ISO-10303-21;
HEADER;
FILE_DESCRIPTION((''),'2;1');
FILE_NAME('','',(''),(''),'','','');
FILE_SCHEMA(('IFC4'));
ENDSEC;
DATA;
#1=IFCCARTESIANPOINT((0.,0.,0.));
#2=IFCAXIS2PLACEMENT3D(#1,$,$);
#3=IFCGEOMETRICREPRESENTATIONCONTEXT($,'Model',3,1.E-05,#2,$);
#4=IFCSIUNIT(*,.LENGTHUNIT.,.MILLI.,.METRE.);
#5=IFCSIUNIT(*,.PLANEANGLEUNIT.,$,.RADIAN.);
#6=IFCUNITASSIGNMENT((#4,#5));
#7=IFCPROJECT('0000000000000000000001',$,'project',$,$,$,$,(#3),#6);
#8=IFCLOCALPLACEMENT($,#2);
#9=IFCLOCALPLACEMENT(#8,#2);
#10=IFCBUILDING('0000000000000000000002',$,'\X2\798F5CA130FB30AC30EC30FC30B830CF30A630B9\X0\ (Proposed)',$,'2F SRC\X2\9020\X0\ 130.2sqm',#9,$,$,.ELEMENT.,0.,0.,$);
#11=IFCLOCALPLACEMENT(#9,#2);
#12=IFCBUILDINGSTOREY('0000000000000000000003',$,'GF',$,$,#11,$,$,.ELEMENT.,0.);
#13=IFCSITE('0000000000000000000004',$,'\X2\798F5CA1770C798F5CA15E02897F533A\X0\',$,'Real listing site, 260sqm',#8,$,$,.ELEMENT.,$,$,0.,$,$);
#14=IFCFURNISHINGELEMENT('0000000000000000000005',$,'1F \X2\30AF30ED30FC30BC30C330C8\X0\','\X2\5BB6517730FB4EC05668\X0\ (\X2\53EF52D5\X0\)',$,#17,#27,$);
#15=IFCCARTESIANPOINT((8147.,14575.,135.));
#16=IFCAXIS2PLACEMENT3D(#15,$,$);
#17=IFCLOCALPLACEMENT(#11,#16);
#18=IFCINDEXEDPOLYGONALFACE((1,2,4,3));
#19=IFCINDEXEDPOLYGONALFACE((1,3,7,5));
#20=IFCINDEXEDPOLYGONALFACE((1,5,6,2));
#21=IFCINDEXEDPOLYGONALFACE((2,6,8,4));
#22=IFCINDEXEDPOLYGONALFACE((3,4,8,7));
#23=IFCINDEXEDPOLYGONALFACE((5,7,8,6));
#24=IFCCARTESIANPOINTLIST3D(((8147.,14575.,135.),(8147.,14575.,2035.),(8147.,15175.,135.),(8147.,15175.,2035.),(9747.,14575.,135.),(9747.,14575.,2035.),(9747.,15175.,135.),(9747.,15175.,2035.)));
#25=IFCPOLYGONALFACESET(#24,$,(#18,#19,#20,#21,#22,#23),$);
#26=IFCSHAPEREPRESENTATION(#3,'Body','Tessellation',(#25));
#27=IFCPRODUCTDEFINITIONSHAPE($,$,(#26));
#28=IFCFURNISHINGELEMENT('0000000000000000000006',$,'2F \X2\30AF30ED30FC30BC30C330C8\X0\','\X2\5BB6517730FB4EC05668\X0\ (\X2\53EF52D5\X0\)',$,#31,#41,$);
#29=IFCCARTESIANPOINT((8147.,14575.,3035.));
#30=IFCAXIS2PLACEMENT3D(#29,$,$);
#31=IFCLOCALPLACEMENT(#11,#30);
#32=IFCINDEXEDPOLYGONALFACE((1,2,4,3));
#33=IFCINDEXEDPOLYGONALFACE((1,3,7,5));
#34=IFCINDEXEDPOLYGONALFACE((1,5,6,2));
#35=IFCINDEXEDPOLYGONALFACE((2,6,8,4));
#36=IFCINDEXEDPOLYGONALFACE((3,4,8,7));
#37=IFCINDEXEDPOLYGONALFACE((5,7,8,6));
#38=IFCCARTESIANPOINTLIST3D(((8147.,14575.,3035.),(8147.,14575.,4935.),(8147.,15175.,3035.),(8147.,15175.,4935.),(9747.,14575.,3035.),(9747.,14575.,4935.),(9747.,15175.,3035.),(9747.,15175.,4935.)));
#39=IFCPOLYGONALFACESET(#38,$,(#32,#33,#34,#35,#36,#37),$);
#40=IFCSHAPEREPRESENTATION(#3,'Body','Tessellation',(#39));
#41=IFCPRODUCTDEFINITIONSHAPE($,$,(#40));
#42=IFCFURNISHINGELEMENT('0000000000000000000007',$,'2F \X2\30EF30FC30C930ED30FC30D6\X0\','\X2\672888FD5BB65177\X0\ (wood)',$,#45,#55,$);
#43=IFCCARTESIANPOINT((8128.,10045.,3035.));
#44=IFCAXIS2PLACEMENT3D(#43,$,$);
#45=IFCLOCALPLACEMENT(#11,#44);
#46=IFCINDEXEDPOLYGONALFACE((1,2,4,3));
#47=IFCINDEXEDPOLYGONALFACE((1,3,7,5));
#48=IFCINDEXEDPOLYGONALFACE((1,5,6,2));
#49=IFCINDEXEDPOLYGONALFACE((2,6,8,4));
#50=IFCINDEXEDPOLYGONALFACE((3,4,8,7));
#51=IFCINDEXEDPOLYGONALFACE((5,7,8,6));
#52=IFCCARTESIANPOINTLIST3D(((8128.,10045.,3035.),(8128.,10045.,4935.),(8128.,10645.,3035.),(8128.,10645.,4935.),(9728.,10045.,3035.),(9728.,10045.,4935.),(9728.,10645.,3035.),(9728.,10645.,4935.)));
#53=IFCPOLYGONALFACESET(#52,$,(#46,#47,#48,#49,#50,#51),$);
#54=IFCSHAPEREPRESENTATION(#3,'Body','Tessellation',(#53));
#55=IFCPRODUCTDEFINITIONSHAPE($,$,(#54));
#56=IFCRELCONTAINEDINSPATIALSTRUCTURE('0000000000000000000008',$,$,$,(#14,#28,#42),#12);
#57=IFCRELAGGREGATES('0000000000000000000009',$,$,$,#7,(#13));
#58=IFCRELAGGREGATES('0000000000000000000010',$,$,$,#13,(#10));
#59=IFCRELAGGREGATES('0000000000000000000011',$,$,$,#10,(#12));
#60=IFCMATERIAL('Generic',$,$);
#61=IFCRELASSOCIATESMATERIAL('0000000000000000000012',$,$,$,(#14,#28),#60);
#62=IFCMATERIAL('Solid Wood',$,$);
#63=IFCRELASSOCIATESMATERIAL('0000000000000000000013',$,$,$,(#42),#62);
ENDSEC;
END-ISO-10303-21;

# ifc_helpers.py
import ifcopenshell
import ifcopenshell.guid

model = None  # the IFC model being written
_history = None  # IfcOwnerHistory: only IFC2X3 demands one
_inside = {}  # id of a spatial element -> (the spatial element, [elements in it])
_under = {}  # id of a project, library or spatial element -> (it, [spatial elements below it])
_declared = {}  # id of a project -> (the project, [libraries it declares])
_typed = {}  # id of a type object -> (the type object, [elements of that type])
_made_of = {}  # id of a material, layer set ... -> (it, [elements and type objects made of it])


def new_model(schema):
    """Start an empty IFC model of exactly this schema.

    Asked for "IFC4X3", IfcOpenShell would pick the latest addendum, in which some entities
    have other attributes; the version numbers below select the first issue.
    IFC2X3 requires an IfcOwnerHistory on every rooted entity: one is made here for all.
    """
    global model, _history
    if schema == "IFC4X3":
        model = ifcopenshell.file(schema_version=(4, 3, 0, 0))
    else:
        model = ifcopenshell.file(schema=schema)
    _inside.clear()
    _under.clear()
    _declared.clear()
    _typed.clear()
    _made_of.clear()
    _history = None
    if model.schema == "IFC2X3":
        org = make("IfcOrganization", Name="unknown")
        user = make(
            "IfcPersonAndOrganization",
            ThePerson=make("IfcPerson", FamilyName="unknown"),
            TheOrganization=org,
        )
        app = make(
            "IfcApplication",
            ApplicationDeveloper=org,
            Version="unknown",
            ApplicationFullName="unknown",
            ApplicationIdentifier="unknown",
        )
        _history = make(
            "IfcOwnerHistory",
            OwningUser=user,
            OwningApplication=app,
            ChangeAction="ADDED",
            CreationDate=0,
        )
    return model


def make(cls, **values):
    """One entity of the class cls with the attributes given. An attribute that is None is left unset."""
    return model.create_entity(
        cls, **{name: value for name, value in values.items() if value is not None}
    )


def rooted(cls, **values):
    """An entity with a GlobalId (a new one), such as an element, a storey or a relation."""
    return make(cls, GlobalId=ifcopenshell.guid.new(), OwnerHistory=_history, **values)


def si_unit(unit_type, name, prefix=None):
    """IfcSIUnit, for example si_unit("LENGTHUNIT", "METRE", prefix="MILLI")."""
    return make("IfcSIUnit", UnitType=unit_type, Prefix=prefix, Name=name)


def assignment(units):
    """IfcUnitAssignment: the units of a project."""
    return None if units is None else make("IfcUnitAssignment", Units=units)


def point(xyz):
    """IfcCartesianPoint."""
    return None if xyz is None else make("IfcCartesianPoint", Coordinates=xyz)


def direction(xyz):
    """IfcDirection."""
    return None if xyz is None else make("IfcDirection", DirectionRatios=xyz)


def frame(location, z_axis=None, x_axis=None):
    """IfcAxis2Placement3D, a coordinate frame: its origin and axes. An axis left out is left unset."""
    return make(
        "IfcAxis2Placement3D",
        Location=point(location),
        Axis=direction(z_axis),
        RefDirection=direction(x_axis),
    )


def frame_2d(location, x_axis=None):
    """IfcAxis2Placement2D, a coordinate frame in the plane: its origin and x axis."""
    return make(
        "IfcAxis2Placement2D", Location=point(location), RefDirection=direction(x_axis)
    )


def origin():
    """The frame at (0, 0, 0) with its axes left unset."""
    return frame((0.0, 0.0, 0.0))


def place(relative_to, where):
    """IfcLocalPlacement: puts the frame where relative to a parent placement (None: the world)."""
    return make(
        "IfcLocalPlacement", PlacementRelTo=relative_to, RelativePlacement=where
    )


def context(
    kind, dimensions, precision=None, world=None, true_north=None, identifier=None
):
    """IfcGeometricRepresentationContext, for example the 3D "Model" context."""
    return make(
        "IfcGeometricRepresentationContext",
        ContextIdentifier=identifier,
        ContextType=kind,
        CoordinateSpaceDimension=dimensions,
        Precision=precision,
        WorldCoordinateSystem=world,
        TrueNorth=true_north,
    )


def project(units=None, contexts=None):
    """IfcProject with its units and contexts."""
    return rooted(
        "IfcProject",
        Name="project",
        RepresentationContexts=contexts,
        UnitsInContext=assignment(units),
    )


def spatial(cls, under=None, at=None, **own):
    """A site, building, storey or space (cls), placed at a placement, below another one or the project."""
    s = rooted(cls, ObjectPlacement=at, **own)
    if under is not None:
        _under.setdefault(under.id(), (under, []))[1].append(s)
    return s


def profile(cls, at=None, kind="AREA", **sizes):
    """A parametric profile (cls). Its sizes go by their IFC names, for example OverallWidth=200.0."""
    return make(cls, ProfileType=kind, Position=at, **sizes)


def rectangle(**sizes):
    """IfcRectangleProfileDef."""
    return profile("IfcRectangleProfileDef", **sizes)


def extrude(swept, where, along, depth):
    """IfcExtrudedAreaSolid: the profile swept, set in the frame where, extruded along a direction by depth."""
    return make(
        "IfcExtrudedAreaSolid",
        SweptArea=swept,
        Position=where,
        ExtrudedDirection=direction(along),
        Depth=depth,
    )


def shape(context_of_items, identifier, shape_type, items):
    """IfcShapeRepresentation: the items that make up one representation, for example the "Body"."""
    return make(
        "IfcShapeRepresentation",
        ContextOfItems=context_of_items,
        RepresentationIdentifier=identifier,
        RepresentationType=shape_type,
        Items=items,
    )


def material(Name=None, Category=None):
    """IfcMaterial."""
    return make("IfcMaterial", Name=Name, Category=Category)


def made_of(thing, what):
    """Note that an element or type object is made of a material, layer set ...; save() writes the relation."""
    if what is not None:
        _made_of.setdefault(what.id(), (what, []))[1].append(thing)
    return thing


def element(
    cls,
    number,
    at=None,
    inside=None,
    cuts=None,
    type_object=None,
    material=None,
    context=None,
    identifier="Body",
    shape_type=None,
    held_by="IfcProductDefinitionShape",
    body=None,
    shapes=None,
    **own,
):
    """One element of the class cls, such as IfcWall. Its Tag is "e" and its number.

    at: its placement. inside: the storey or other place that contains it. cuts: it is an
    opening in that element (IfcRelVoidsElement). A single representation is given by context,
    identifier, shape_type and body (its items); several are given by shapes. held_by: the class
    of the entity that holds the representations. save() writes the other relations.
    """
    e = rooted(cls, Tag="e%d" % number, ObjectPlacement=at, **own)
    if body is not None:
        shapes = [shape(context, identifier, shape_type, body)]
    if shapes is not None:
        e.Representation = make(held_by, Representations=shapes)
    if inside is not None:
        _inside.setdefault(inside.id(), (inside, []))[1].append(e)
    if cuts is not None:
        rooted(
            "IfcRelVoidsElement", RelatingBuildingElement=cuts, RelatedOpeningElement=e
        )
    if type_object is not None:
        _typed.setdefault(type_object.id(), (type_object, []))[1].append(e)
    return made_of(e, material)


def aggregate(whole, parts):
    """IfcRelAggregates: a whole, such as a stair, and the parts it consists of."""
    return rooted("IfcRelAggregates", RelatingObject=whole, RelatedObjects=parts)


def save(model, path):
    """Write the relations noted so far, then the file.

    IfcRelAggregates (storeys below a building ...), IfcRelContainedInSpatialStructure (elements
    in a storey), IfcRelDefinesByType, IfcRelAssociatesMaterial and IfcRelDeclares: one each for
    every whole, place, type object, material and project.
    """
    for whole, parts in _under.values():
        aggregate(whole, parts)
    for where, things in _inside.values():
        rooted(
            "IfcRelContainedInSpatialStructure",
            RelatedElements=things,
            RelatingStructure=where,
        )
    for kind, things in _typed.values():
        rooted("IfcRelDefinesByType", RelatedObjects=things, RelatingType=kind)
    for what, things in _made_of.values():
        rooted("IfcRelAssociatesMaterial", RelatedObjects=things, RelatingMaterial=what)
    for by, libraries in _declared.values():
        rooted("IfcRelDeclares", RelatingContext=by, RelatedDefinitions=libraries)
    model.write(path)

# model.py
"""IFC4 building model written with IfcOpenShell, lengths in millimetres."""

from ifc_helpers import new_model, si_unit, frame, frame_2d, origin, place, context, project, spatial, rectangle, extrude, material, element, save


model = new_model("IFC4")

# Units and contexts
model_context = context("Model", 3, precision=1e-05, world=origin())
ifc_project = project(units=[si_unit("LENGTHUNIT", "METRE", prefix="MILLI"), si_unit("PLANEANGLEUNIT", "RADIAN")], contexts=[model_context])

# Site, building, storey
site_placement = place(None, origin())
site = spatial("IfcSite", under=ifc_project, at=site_placement, Name="福岡県福岡市西区", ObjectType="Real listing site, 260sqm", CompositionType="ELEMENT", RefElevation=0.0)
building_placement = place(site_placement, origin())
building = spatial("IfcBuilding", under=site, at=building_placement, Name="福岡・ガレージハウス (Proposed)", ObjectType="2F SRC造 130.2sqm", CompositionType="ELEMENT", ElevationOfRefHeight=0.0, ElevationOfTerrain=0.0)
storey_placement = place(building_placement, origin())
storey = spatial("IfcBuildingStorey", under=building, at=storey_placement, Name="GF", CompositionType="ELEMENT", Elevation=0.0)

# Shared definitions
ifc_material_1 = material(Name="Solid Wood")

# Shared definitions
ifc_material_2 = material(Name="Generic")

# Furnishing elements
furnishing_1_placement = place(storey_placement, frame((8147.0, 14575.0, 135.0)))
element("IfcFurnishingElement", 1, at=furnishing_1_placement, inside=storey, material=ifc_material_2, Name="1F クローゼット", Description="家具・什器 (可動)", context=model_context, shape_type="SweptSolid", body=[
    extrude(rectangle(XDim=1600.0, YDim=600.0, at=frame_2d((800.0, 300.0))), frame((8147.0, 14575.0, 135.0)), (0.0, 0.0, 1.0), 1900.0),
])
furnishing_2_placement = place(storey_placement, frame((8147.0, 14575.0, 3035.0)))
element("IfcFurnishingElement", 2, at=furnishing_2_placement, inside=storey, material=ifc_material_2, Name="2F クローゼット", Description="家具・什器 (可動)", context=model_context, shape_type="SweptSolid", body=[
    extrude(rectangle(XDim=1600.0, YDim=600.0, at=frame_2d((800.0, 300.0))), frame((8147.0, 14575.0, 3035.0)), (0.0, 0.0, 1.0), 1900.0),
])
furnishing_3_placement = place(storey_placement, frame((8128.0, 10045.0, 3035.0)))
element("IfcFurnishingElement", 3, at=furnishing_3_placement, inside=storey, material=ifc_material_1, Name="2F ワードローブ", Description="木製家具 (wood)", context=model_context, shape_type="SweptSolid", body=[
    extrude(rectangle(XDim=1600.0, YDim=600.0, at=frame_2d((800.0, 300.0))), frame((8128.0, 10045.0, 3035.0)), (0.0, 0.0, 1.0), 1900.0),
])

save(model, "model.ifc")
